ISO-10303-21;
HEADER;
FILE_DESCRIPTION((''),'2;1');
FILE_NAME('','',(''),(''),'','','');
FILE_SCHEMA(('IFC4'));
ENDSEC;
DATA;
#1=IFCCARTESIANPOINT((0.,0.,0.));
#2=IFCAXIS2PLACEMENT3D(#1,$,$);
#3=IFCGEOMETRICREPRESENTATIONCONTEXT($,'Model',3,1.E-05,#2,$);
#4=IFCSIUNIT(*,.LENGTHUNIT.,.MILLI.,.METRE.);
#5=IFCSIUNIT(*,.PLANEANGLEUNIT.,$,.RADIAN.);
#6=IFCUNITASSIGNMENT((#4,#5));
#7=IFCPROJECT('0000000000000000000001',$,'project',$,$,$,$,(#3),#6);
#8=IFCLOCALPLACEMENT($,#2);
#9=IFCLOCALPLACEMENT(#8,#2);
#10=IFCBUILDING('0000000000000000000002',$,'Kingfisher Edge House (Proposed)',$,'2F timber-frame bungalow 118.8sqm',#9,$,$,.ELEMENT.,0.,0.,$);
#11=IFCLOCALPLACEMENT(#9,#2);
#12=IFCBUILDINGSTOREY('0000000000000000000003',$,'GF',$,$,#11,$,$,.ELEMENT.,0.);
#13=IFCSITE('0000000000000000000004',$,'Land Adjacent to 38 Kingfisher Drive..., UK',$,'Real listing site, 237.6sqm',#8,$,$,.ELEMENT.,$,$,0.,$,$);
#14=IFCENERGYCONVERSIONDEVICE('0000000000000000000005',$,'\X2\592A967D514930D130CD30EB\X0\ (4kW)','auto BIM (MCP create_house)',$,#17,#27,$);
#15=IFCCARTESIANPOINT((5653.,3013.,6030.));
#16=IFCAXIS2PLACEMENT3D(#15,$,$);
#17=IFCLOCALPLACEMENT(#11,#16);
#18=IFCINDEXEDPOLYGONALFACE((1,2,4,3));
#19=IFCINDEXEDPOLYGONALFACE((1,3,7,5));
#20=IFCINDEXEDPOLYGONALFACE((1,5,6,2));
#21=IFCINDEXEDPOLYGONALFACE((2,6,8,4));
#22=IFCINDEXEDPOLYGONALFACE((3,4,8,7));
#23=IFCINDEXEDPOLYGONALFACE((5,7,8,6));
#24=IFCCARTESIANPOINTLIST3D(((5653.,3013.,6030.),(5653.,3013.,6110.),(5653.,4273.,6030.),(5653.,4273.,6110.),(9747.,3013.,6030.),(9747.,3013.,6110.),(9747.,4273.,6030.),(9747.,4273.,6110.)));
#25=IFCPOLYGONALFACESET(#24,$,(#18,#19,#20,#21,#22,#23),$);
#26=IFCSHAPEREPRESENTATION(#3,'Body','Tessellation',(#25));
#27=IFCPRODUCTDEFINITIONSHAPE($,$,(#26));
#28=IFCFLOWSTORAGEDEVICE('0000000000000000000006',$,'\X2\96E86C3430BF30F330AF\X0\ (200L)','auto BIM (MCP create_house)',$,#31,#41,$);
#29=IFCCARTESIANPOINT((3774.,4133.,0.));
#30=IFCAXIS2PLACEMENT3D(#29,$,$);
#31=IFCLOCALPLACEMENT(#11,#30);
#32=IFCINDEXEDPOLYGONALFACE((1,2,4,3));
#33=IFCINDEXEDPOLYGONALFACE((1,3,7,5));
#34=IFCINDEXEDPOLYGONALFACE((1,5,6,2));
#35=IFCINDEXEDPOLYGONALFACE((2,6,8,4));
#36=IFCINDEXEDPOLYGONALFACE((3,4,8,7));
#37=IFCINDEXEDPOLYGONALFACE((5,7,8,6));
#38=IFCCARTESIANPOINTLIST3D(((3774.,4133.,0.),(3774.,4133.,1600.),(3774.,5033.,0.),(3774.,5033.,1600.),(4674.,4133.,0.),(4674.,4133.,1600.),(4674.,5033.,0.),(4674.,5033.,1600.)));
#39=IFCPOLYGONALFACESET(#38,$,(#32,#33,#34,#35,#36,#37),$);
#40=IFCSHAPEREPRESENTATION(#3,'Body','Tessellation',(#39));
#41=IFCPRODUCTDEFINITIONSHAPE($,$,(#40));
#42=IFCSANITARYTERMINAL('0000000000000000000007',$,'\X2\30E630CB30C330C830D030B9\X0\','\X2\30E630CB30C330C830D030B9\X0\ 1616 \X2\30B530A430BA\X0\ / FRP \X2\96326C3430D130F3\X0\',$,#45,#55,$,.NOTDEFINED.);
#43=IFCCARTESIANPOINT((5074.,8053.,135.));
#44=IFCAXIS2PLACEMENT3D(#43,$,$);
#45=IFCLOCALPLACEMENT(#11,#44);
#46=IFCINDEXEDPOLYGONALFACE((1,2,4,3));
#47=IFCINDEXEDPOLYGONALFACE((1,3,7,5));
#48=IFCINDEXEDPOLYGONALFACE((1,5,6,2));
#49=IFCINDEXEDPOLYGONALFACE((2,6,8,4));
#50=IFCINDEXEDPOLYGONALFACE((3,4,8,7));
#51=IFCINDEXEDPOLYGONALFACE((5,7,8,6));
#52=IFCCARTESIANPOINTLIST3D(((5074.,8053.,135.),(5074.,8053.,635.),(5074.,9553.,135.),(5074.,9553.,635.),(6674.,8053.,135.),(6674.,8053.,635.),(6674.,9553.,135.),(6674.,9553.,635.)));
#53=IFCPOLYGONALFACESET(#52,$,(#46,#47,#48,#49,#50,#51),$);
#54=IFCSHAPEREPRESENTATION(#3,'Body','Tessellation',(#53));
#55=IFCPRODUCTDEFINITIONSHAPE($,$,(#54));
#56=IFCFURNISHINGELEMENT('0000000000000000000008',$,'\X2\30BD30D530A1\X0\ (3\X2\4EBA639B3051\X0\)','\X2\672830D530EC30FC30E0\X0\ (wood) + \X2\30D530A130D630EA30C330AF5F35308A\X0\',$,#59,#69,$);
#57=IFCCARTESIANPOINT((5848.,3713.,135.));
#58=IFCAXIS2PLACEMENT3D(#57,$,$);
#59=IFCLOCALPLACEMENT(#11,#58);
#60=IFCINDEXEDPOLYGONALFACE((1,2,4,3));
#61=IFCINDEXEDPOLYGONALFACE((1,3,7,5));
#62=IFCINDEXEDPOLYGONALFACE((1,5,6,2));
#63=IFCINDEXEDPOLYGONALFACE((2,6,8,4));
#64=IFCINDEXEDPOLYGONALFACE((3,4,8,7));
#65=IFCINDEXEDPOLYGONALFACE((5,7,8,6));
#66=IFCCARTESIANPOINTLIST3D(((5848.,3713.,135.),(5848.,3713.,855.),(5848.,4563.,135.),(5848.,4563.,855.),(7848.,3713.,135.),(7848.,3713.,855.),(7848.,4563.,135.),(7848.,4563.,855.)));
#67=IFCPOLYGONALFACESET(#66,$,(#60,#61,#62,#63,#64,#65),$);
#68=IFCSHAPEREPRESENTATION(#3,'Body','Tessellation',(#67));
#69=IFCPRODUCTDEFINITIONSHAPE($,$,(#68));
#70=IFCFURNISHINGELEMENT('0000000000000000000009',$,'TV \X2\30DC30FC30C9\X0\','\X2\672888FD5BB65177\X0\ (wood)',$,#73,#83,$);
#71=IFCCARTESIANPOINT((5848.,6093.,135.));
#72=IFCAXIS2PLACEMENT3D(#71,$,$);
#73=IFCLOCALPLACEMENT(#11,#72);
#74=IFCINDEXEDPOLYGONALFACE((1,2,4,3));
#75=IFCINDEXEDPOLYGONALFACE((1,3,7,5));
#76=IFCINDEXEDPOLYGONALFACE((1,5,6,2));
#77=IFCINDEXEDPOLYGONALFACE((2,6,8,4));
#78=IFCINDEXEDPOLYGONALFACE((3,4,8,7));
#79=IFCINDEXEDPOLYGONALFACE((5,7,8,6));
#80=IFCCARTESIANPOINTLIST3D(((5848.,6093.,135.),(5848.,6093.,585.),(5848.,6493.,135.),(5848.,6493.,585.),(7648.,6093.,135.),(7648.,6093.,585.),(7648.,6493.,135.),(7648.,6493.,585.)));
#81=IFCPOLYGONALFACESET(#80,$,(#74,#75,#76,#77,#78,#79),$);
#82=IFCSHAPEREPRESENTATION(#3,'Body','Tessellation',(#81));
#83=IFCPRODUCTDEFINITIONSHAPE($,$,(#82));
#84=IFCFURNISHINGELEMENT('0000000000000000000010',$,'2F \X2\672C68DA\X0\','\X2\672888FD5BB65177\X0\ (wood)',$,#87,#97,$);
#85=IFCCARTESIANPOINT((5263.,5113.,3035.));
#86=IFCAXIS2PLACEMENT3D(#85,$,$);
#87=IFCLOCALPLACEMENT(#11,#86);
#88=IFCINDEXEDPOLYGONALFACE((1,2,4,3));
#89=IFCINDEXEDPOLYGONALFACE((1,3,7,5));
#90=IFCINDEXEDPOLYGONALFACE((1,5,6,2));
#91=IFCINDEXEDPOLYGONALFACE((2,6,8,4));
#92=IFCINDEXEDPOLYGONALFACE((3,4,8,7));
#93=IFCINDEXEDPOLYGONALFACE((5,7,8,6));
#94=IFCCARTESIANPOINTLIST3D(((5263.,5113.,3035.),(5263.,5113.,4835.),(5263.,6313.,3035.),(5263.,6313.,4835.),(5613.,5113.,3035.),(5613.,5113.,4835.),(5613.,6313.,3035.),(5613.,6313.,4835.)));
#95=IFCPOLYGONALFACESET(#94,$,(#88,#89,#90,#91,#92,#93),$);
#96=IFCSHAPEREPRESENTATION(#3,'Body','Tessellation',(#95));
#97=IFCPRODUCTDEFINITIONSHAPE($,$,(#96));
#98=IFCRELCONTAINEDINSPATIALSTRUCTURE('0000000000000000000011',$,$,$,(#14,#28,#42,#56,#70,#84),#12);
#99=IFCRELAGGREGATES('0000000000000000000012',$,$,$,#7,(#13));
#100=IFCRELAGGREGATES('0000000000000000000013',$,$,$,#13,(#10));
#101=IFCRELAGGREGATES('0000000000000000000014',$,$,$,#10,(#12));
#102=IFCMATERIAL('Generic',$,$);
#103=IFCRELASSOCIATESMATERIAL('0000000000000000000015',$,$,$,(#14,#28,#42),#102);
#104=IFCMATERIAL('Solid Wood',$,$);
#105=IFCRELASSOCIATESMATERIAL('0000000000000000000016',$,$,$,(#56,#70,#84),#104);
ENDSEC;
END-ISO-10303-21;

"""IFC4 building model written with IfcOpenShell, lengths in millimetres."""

from ifc_helpers import new_model, si_unit, frame, frame_2d, origin, place, context, project, spatial, rectangle, extrude, material, element, save


model = new_model("IFC4")

# Units and contexts
model_context = context("Model", 3, precision=1e-05, world=origin())
ifc_project = project(units=[si_unit("LENGTHUNIT", "METRE", prefix="MILLI"), si_unit("PLANEANGLEUNIT", "RADIAN")], contexts=[model_context])

# Site, building, storey
site_placement = place(None, origin())
site = spatial("IfcSite", under=ifc_project, at=site_placement, Name="Land Adjacent to 38 Kingfisher Drive..., UK", ObjectType="Real listing site, 237.6sqm", CompositionType="ELEMENT", RefElevation=0.0)
building_placement = place(site_placement, origin())
building = spatial("IfcBuilding", under=site, at=building_placement, Name="Kingfisher Edge House (Proposed)", ObjectType="2F timber-frame bungalow 118.8sqm", CompositionType="ELEMENT", ElevationOfRefHeight=0.0, ElevationOfTerrain=0.0)
storey_placement = place(building_placement, origin())
storey = spatial("IfcBuildingStorey", under=building, at=storey_placement, Name="GF", CompositionType="ELEMENT", Elevation=0.0)

# Shared definitions
ifc_material_1 = material(Name="Solid Wood")

# Energy conversion device
ifc_material_2 = material(Name="Generic")
energy_conversion_device_placement = place(storey_placement, frame((5653.0, 3013.0, 6030.0)))
element("IfcEnergyConversionDevice", 1, at=energy_conversion_device_placement, inside=storey, material=ifc_material_2, Name="太陽光パネル (4kW)", Description="auto BIM (MCP create_house)", context=model_context, shape_type="SweptSolid", body=[
    extrude(rectangle(XDim=4094.0, YDim=1260.0, at=frame_2d((2047.0, 630.0))), frame((5653.0, 3013.0, 6030.0)), (0.0, 0.0, 1.0), 80.0),
])

# Flow storage device
flow_storage_device_placement = place(storey_placement, frame((3774.0, 4133.0, 0.0)))
element("IfcFlowStorageDevice", 2, at=flow_storage_device_placement, inside=storey, material=ifc_material_2, Name="雨水タンク (200L)", Description="auto BIM (MCP create_house)", context=model_context, shape_type="SweptSolid", body=[
    extrude(rectangle(XDim=900.0, YDim=900.0, at=frame_2d((450.0, 450.0))), frame((3774.0, 4133.0, 0.0)), (0.0, 0.0, 1.0), 1600.0),
])

# Sanitary terminal
sanitary_terminal_placement = place(storey_placement, frame((5074.0, 8053.0, 135.0)))
element("IfcSanitaryTerminal", 3, at=sanitary_terminal_placement, inside=storey, material=ifc_material_2, Name="ユニットバス", Description="ユニットバス 1616 サイズ / FRP 防水パン", PredefinedType="NOTDEFINED", context=model_context, shape_type="SweptSolid", body=[
    extrude(rectangle(XDim=1600.0, YDim=1500.0, at=frame_2d((800.0, 750.0))), frame((5074.0, 8053.0, 135.0)), (0.0, 0.0, 1.0), 500.0),
])

# Furnishing elements
furnishing_1_placement = place(storey_placement, frame((5848.0, 3713.0, 135.0)))
element("IfcFurnishingElement", 4, at=furnishing_1_placement, inside=storey, material=ifc_material_1, Name="ソファ (3人掛け)", Description="木フレーム (wood) + ファブリック張り", context=model_context, shape_type="SweptSolid", body=[
    extrude(rectangle(XDim=2000.0, YDim=850.0, at=frame_2d((1000.0, 425.0))), frame((5848.0, 3713.0, 135.0)), (0.0, 0.0, 1.0), 720.0),
])
furnishing_2_placement = place(storey_placement, frame((5848.0, 6093.0, 135.0)))
element("IfcFurnishingElement", 5, at=furnishing_2_placement, inside=storey, material=ifc_material_1, Name="TV ボード", Description="木製家具 (wood)", context=model_context, shape_type="SweptSolid", body=[
    extrude(rectangle(XDim=1800.0, YDim=400.0, at=frame_2d((900.0, 200.0))), frame((5848.0, 6093.0, 135.0)), (0.0, 0.0, 1.0), 450.0),
])
furnishing_3_placement = place(storey_placement, frame((5263.0, 5113.0, 3035.0)))
element("IfcFurnishingElement", 6, at=furnishing_3_placement, inside=storey, material=ifc_material_1, Name="2F 本棚", Description="木製家具 (wood)", context=model_context, shape_type="SweptSolid", body=[
    extrude(rectangle(XDim=350.0, YDim=1200.0, at=frame_2d((175.0, 600.0))), frame((5263.0, 5113.0, 3035.0)), (0.0, 0.0, 1.0), 1800.0),
])

save(model, "model.ifc")
